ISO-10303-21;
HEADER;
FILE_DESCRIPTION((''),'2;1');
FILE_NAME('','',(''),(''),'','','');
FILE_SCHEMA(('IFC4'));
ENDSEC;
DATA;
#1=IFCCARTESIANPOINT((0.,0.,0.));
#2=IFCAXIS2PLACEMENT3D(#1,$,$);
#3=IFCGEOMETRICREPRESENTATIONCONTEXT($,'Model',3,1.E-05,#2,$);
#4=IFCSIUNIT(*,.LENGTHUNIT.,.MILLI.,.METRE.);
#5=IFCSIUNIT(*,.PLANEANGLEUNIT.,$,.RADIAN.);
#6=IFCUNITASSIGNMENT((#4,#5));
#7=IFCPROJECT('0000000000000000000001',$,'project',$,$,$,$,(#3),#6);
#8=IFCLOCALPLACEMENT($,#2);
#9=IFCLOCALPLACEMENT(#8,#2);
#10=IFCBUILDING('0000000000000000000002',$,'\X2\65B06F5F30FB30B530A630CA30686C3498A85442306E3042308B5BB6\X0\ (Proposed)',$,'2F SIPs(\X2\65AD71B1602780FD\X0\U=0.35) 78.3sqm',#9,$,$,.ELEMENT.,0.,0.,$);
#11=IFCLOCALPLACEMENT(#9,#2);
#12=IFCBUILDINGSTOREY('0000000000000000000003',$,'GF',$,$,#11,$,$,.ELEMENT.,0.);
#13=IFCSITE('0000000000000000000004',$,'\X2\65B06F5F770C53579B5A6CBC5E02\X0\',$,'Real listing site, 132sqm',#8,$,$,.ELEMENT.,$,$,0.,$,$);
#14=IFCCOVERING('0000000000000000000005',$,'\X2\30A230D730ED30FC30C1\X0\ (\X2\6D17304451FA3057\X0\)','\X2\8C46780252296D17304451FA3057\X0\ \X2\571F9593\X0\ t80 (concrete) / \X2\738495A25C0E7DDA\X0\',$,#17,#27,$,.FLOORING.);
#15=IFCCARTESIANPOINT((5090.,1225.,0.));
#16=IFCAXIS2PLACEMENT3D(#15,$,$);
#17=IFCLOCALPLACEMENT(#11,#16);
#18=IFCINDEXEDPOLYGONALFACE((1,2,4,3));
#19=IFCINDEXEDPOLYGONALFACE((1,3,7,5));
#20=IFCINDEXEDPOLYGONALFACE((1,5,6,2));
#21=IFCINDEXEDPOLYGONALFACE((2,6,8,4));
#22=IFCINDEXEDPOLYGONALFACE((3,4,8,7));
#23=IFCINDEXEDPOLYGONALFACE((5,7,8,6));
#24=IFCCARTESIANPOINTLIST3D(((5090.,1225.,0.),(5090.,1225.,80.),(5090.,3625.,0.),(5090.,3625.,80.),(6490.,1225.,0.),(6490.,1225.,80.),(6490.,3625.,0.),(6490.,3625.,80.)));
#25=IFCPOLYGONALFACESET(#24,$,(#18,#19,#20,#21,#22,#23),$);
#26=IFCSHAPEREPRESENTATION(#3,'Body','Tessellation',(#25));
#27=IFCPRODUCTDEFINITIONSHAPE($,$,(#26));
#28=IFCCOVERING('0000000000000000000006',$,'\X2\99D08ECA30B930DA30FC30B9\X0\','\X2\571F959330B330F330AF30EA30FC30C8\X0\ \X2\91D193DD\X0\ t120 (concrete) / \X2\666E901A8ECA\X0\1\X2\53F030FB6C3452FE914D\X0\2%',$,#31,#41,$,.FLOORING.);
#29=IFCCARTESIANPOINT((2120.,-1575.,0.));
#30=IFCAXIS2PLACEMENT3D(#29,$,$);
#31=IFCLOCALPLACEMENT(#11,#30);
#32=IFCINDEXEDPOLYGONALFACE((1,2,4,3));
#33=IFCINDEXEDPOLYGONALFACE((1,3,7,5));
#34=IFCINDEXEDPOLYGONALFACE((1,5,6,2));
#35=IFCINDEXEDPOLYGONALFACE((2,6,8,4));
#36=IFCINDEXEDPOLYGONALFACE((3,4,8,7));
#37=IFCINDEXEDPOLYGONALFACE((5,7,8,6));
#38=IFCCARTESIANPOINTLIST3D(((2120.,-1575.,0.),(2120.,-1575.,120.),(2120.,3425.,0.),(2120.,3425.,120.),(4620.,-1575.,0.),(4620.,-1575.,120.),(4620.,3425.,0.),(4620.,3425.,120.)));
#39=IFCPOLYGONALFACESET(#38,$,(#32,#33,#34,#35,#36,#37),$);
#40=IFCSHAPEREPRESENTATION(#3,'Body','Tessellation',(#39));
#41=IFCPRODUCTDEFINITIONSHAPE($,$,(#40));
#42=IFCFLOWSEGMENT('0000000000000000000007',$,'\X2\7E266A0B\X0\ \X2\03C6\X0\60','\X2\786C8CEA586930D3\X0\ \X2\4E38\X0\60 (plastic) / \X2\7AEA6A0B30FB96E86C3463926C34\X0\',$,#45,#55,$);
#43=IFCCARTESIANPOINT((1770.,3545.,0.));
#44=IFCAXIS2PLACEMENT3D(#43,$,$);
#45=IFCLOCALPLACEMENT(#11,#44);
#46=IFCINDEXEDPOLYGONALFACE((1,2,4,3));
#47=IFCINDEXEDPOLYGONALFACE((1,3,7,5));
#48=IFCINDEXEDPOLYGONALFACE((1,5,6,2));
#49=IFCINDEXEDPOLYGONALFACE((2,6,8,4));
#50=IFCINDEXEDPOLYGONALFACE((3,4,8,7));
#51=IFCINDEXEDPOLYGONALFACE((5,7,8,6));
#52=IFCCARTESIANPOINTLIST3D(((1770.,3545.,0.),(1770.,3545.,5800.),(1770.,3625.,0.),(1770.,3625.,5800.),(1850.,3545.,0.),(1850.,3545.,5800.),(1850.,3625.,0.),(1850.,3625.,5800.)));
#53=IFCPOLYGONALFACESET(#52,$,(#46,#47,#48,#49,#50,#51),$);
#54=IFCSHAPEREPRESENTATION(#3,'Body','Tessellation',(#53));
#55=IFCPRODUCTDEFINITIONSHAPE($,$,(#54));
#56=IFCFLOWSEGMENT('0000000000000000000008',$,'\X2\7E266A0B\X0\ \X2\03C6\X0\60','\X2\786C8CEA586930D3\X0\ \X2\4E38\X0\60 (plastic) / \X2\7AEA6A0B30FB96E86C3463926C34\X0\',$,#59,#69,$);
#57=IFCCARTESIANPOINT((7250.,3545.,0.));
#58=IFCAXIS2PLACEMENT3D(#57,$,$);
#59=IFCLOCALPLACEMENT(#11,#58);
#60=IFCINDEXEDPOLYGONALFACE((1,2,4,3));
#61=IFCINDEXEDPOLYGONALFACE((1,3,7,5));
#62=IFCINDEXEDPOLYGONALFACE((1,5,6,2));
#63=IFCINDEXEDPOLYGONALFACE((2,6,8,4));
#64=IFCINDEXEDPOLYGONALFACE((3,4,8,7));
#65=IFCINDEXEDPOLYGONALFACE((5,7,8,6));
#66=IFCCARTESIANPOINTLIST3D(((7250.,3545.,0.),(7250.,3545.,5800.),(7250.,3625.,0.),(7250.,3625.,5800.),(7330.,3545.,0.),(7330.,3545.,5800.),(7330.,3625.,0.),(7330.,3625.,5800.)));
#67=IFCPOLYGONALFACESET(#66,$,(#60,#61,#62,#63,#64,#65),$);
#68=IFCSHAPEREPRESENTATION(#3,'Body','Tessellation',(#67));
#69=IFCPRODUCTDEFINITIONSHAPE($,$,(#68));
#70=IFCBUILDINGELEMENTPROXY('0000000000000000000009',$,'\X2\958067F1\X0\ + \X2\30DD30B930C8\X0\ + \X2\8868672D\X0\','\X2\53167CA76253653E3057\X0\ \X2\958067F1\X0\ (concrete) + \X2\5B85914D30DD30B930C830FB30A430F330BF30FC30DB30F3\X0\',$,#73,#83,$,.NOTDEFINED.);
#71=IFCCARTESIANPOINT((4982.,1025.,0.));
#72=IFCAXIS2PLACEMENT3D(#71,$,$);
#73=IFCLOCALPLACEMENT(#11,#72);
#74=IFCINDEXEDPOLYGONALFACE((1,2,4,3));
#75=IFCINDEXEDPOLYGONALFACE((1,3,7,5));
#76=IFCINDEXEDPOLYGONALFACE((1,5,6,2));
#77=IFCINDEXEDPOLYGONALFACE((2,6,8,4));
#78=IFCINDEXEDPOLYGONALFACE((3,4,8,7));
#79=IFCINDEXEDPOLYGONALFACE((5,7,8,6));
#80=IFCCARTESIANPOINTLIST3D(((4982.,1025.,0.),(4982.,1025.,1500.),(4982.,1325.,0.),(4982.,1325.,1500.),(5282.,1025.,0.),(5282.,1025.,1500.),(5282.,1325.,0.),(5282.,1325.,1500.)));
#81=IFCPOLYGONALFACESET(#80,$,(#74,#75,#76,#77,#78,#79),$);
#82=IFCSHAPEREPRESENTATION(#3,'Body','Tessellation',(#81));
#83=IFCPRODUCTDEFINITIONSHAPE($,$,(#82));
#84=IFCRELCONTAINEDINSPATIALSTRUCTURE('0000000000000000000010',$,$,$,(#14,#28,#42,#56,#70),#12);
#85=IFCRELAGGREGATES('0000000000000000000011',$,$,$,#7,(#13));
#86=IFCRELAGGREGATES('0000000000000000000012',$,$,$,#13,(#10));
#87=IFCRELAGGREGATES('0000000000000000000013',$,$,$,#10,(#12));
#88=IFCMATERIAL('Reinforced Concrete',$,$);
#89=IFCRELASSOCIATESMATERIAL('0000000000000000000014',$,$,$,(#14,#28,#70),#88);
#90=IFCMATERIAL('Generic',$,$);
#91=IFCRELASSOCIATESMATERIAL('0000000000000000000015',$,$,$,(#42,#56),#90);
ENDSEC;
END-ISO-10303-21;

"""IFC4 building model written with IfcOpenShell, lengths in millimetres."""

from ifc_helpers import new_model, si_unit, frame, frame_2d, origin, place, context, project, spatial, rectangle, extrude, material, element, save


model = new_model("IFC4")

# Units and contexts
model_context = context("Model", 3, precision=1e-05, world=origin())
ifc_project = project(units=[si_unit("LENGTHUNIT", "METRE", prefix="MILLI"), si_unit("PLANEANGLEUNIT", "RADIAN")], contexts=[model_context])

# Site, building, storey
site_placement = place(None, origin())
site = spatial("IfcSite", under=ifc_project, at=site_placement, Name="新潟県南魚沼市", ObjectType="Real listing site, 132sqm", CompositionType="ELEMENT", RefElevation=0.0)
building_placement = place(site_placement, origin())
building = spatial("IfcBuilding", under=site, at=building_placement, Name="新潟・サウナと水風呂のある家 (Proposed)", ObjectType="2F SIPs(断熱性能U=0.35) 78.3sqm", CompositionType="ELEMENT", ElevationOfRefHeight=0.0, ElevationOfTerrain=0.0)
storey_placement = place(building_placement, origin())
storey = spatial("IfcBuildingStorey", under=building, at=storey_placement, Name="GF", CompositionType="ELEMENT", Elevation=0.0)

# Shared definitions
ifc_material_1 = material(Name="Reinforced Concrete")

# Coverings
covering_1_placement = place(storey_placement, frame((5090.0, 1225.0, 0.0)))
element("IfcCovering", 1, at=covering_1_placement, inside=storey, material=ifc_material_1, Name="アプローチ (洗い出し)", Description="豆砂利洗い出し 土間 t80 (concrete) / 玄関導線", PredefinedType="FLOORING", context=model_context, shape_type="SweptSolid", body=[
    extrude(rectangle(XDim=1400.0, YDim=2400.0, at=frame_2d((700.0, 1200.0))), frame((5090.0, 1225.0, 0.0)), (0.0, 0.0, 1.0), 80.0),
])
covering_2_placement = place(storey_placement, frame((2120.0, -1575.0, 0.0)))
element("IfcCovering", 2, at=covering_2_placement, inside=storey, material=ifc_material_1, Name="駐車スペース", Description="土間コンクリート 金鏝 t120 (concrete) / 普通車1台・水勾配2%", PredefinedType="FLOORING", context=model_context, shape_type="SweptSolid", body=[
    extrude(rectangle(XDim=2500.0, YDim=5000.0, at=frame_2d((1250.0, 2500.0))), frame((2120.0, -1575.0, 0.0)), (0.0, 0.0, 1.0), 120.0),
])

# Flow segments
ifc_material_2 = material(Name="Generic")
flow_segment_1_placement = place(storey_placement, frame((1770.0, 3545.0, 0.0)))
element("IfcFlowSegment", 3, at=flow_segment_1_placement, inside=storey, material=ifc_material_2, Name="縦樋 φ60", Description="硬質塩ビ 丸60 (plastic) / 竪樋・雨水排水", context=model_context, shape_type="SweptSolid", body=[
    extrude(rectangle(XDim=80.0, YDim=80.0, at=frame_2d((40.0, 40.0))), frame((1770.0, 3545.0, 0.0)), (0.0, 0.0, 1.0), 5800.0),
])
flow_segment_2_placement = place(storey_placement, frame((7250.0, 3545.0, 0.0)))
element("IfcFlowSegment", 4, at=flow_segment_2_placement, inside=storey, material=ifc_material_2, Name="縦樋 φ60", Description="硬質塩ビ 丸60 (plastic) / 竪樋・雨水排水", context=model_context, shape_type="SweptSolid", body=[
    extrude(rectangle(XDim=80.0, YDim=80.0, at=frame_2d((40.0, 40.0))), frame((7250.0, 3545.0, 0.0)), (0.0, 0.0, 1.0), 5800.0),
])

# Building element proxy
proxy_placement = place(storey_placement, frame((4982.0, 1025.0, 0.0)))
element("IfcBuildingElementProxy", 5, at=proxy_placement, inside=storey, material=ifc_material_1, Name="門柱 + ポスト + 表札", Description="化粧打放し 門柱 (concrete) + 宅配ポスト・インターホン", PredefinedType="NOTDEFINED", context=model_context, shape_type="SweptSolid", body=[
    extrude(rectangle(XDim=300.0, YDim=300.0, at=frame_2d((150.0, 150.0))), frame((4982.0, 1025.0, 0.0)), (0.0, 0.0, 1.0), 1500.0),
])

save(model, "model.ifc")
